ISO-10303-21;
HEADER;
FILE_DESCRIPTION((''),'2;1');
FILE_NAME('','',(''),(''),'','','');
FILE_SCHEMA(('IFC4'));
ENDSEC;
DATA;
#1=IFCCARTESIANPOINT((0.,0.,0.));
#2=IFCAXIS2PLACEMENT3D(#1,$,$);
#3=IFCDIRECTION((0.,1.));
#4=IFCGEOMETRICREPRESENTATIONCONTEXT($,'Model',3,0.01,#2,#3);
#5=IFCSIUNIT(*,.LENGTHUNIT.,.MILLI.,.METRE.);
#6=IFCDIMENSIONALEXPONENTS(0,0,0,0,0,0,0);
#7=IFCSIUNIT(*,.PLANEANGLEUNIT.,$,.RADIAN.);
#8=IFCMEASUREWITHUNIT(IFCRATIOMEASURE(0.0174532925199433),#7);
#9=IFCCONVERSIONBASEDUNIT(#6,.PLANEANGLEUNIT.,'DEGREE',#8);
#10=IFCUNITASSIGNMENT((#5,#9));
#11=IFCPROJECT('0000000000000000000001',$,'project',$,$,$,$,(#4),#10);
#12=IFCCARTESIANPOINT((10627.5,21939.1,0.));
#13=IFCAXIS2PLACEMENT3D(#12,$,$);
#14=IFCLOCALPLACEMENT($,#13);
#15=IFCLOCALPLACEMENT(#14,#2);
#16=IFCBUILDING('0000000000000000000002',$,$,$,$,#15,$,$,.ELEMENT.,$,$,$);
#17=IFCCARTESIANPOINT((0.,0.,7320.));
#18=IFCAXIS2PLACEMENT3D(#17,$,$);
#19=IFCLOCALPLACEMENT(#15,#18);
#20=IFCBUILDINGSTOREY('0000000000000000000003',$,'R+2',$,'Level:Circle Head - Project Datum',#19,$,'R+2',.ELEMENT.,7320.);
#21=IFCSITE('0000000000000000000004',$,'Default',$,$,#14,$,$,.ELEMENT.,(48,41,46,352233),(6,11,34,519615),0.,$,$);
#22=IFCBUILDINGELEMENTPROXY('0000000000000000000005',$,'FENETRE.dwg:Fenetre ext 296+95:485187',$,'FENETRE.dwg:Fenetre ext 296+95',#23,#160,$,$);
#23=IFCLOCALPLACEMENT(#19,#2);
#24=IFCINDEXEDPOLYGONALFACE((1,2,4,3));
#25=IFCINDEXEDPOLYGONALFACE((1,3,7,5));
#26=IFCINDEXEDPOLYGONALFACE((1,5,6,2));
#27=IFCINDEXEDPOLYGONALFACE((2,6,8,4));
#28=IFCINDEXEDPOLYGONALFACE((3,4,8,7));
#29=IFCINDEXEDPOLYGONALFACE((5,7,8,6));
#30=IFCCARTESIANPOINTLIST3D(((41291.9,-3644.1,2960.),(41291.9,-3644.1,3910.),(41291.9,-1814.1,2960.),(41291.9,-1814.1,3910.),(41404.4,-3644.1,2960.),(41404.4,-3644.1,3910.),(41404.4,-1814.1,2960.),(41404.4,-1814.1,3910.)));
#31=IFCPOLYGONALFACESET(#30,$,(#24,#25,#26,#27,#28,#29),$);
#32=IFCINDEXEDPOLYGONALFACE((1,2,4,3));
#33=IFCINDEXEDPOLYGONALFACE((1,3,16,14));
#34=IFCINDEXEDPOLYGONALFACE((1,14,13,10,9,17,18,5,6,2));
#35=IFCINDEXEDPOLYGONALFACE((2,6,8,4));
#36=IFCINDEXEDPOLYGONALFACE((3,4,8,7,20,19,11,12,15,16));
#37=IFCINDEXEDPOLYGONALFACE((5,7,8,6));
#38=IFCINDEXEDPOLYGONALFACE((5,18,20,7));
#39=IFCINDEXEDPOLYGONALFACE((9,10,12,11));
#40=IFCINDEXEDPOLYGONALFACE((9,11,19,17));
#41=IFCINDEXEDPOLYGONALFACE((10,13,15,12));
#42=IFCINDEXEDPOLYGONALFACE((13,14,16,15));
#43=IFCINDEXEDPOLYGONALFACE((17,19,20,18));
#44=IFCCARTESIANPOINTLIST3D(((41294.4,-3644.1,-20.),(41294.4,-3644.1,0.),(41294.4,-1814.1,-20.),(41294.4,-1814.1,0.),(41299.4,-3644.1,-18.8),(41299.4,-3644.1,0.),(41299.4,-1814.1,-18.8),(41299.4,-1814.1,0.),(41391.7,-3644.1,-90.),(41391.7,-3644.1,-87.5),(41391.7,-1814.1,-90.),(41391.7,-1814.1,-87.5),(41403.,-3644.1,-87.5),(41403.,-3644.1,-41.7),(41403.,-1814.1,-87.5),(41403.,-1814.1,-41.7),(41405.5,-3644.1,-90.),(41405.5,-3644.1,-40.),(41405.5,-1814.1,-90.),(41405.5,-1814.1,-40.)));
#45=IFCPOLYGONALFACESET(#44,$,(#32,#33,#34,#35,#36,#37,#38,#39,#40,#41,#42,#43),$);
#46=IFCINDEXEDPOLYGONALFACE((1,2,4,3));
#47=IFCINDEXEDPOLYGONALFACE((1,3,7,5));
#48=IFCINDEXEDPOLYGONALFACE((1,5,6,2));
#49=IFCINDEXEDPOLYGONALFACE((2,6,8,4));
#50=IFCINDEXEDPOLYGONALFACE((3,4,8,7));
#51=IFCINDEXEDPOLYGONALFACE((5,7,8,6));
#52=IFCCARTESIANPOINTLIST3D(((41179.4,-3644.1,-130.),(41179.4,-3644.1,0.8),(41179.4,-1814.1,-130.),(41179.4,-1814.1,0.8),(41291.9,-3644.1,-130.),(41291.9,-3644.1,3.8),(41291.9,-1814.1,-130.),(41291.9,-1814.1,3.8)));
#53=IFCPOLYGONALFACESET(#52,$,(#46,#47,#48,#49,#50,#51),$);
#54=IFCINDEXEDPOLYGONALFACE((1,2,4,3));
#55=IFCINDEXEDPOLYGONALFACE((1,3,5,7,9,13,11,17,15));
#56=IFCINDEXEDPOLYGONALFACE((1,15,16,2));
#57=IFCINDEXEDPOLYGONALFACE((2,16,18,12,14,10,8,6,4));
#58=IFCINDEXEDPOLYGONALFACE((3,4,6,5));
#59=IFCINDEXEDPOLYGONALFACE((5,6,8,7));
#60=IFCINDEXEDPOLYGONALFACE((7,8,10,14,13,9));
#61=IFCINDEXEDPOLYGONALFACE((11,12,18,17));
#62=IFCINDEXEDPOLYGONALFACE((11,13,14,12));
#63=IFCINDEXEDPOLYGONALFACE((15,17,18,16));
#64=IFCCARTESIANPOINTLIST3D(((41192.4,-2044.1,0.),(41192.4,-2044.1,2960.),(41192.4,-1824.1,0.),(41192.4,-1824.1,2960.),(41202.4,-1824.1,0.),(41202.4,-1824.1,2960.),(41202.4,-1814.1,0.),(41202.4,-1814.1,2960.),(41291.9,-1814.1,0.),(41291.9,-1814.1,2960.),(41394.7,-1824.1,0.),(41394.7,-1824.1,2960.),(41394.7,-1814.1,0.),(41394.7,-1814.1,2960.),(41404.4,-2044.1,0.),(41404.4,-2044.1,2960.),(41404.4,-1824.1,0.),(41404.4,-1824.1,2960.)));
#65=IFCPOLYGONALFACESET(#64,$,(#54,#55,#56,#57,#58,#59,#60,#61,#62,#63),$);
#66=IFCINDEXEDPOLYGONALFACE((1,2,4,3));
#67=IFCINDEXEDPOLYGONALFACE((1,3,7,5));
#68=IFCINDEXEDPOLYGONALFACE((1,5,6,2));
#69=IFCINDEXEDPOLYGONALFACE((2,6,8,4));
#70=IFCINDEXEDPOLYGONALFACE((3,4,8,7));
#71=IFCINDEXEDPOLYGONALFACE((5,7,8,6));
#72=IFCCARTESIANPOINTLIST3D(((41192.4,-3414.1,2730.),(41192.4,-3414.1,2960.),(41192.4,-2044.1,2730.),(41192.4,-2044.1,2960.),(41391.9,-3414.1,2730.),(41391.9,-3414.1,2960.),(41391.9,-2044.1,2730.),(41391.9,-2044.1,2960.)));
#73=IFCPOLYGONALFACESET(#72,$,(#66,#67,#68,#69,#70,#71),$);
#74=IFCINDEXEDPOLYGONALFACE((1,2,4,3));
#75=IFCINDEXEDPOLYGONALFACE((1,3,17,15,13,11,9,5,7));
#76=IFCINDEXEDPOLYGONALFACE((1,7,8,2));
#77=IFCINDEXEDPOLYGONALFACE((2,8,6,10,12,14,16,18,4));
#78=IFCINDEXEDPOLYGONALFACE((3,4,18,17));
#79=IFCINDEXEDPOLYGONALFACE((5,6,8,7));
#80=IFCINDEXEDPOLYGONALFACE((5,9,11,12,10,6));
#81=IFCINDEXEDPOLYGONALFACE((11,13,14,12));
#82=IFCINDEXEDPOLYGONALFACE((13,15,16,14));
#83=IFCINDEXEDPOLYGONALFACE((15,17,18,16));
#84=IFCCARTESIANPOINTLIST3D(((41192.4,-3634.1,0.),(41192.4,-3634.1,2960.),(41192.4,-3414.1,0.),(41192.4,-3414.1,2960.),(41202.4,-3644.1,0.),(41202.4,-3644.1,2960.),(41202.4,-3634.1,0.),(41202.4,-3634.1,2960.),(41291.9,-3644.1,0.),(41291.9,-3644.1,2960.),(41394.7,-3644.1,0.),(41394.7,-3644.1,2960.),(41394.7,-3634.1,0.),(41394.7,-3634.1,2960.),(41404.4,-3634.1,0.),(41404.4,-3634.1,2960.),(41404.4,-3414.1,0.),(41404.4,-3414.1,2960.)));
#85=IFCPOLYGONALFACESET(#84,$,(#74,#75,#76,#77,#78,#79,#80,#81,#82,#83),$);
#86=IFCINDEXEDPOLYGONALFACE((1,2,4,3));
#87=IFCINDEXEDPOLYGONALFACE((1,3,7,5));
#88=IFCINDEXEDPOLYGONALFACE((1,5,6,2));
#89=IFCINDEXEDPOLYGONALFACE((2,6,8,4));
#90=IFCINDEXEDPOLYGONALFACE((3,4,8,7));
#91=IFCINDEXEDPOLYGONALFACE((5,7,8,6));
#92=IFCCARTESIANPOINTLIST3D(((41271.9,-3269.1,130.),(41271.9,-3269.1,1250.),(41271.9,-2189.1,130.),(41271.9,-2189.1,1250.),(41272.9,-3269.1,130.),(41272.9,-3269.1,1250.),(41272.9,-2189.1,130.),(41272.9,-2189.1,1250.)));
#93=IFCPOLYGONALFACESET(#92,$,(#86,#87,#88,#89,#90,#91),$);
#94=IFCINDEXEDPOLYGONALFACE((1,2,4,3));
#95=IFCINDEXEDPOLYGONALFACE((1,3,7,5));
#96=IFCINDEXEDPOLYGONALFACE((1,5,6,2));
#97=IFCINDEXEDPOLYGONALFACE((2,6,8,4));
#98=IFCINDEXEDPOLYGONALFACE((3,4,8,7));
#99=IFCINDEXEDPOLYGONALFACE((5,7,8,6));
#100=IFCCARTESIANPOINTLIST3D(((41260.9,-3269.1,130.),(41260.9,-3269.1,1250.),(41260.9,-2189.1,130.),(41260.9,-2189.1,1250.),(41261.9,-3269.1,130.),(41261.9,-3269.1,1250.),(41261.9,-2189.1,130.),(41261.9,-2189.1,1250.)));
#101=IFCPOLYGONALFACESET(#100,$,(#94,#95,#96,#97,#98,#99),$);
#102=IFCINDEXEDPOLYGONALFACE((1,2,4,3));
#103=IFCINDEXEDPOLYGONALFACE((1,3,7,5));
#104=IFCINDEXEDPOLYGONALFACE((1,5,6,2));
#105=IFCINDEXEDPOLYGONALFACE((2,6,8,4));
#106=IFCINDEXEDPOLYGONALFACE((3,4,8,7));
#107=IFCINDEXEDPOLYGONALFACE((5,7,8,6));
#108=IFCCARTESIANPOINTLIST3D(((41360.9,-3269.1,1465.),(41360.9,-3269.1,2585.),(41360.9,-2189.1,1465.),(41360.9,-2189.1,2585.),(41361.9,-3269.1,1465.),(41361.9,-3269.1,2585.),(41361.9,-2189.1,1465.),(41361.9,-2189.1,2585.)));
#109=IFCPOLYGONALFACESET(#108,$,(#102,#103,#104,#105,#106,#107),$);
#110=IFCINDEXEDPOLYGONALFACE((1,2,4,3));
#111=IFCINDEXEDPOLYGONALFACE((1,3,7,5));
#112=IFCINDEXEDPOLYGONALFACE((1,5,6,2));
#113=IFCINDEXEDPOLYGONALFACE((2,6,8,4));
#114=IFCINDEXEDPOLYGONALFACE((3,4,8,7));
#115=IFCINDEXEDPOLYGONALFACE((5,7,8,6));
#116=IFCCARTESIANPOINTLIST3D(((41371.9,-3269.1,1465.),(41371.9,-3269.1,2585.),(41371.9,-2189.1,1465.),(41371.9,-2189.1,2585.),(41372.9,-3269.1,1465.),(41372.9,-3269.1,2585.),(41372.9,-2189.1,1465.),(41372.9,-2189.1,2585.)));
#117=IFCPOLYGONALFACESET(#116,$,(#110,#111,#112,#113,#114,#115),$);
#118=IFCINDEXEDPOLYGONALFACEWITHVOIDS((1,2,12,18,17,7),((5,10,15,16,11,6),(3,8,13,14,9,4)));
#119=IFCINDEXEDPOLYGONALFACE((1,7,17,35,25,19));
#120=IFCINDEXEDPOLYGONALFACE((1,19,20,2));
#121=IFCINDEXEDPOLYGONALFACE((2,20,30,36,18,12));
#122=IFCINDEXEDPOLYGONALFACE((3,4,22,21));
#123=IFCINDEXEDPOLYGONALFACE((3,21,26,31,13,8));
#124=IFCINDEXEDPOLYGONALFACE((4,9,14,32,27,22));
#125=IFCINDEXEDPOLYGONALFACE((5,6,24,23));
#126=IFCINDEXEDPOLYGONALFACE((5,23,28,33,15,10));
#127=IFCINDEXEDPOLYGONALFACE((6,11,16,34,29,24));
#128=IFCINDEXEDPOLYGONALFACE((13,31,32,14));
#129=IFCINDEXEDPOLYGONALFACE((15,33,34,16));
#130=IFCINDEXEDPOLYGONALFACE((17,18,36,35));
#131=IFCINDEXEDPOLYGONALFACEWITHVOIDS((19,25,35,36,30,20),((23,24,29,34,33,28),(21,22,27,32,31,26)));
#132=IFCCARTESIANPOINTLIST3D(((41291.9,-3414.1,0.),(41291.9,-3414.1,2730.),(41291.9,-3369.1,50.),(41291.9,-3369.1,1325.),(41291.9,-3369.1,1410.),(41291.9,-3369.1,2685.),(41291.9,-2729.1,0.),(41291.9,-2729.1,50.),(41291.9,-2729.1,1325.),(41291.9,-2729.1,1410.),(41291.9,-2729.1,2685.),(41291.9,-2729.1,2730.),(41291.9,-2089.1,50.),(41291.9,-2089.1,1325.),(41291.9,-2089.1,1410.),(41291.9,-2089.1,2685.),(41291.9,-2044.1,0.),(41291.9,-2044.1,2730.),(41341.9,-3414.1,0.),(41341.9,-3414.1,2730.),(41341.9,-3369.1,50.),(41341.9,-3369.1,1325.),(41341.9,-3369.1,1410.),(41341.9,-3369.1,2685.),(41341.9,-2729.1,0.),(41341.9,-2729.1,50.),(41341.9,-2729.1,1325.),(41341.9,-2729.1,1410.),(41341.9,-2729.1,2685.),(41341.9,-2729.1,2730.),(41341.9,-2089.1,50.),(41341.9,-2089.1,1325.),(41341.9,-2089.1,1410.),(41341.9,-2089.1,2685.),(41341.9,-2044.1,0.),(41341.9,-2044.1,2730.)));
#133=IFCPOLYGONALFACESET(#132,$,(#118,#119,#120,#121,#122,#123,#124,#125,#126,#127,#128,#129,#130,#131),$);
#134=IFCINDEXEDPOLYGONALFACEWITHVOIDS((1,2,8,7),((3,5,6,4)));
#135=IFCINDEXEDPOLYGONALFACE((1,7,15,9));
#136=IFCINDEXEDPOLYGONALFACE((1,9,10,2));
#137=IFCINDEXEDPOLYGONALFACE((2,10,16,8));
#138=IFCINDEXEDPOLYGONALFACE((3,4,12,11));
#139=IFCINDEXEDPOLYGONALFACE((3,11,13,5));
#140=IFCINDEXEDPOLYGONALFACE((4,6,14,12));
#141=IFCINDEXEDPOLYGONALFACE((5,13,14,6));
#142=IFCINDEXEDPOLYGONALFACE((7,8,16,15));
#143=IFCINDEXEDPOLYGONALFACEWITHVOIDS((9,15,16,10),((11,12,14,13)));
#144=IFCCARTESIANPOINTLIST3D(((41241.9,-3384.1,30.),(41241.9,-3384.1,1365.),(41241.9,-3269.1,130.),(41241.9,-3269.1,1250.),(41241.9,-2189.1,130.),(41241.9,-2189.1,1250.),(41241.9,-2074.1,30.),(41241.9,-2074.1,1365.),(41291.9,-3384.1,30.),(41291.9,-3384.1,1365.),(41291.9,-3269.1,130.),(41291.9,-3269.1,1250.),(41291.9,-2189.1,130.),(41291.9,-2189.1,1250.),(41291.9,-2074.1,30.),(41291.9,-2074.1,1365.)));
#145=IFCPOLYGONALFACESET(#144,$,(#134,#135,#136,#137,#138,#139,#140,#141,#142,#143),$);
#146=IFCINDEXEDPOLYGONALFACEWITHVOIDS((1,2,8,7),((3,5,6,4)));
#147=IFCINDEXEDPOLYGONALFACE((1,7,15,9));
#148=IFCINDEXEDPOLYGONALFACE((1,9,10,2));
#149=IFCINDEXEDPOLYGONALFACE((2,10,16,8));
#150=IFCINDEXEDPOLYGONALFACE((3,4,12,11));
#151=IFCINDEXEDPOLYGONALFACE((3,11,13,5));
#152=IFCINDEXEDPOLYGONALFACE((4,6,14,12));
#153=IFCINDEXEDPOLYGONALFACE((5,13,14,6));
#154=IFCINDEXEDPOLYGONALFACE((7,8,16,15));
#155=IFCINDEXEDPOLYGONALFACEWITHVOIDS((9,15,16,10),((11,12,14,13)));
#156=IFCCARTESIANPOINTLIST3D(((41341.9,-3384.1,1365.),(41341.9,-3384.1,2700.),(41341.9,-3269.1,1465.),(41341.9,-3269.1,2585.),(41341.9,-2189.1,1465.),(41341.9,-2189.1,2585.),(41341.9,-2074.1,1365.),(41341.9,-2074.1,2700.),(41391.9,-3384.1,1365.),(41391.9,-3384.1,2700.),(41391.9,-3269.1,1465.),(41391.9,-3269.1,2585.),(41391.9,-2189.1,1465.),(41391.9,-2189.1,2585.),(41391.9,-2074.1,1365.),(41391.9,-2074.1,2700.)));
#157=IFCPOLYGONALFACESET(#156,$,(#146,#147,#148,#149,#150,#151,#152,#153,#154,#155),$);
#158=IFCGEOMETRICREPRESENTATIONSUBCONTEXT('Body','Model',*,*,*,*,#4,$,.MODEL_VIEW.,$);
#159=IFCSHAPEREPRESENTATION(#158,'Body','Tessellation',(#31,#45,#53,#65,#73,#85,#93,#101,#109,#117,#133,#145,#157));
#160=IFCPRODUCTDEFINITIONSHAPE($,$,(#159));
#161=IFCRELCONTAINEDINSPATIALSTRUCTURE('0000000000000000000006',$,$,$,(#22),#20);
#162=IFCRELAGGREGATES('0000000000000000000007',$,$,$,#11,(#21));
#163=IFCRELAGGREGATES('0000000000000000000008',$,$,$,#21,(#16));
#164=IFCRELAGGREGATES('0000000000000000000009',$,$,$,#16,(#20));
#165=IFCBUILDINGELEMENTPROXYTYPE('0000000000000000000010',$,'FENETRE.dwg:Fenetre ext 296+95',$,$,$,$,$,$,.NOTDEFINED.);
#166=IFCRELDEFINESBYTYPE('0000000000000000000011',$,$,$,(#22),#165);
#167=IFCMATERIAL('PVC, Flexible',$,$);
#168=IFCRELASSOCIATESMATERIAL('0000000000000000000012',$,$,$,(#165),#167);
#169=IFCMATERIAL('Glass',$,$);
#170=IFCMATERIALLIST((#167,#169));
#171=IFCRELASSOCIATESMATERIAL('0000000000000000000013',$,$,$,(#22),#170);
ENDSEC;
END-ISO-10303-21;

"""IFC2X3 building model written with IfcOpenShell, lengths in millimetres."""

from ifc_helpers import new_model, entity, si_unit, converted_unit, direction, frame, frame_2d, origin, origin_2d_with_axis, place, context, subcontext, project, spatial, polyline, rectangle, outline, extrude, source, transform, mapped, material, material_list, type_object, type_shapes, element, save


model = new_model("IFC2X3")

# Units and contexts
model_context = context("Model", 3, precision=0.01, world=origin(), true_north=direction((0.0, 1.0)))
body_context = subcontext(model_context, "Body", "Model", "MODEL_VIEW")
ifc_project = project(units=[si_unit("LENGTHUNIT", "METRE", prefix="MILLI"), converted_unit("PLANEANGLEUNIT", "DEGREE", entity("IfcRatioMeasure", 0.0174532925199433), si_unit("PLANEANGLEUNIT", "RADIAN"), dimensions=[0, 0, 0, 0, 0, 0, 0])], contexts=[model_context])

# Site, building, storey
site_placement = place(None, frame((10627.5, 21939.1, 0.0)))
site = spatial("IfcSite", under=ifc_project, at=site_placement, Name="Default", CompositionType="ELEMENT", RefLatitude=(48, 41, 46, 352233), RefLongitude=(6, 11, 34, 519615), RefElevation=0.0)
building_placement = place(site_placement, origin())
building = spatial("IfcBuilding", under=site, at=building_placement, CompositionType="ELEMENT")
storey_placement = place(building_placement, frame((0.0, 0.0, 7320.0)))
storey = spatial("IfcBuildingStorey", under=building, at=storey_placement, Name="R+2", ObjectType="Level:Circle Head - Project Datum", LongName="R+2", CompositionType="ELEMENT", Elevation=7320.0)

# Building element proxy
ifc_material_1 = material(Name="PVC, Flexible")
ifc_material_2 = material(Name="Glass")
building_element_proxy_type_1 = type_object("IfcBuildingElementProxyType", Name="FENETRE.dwg:Fenetre ext 296+95", PredefinedType="NOTDEFINED", material=ifc_material_1)
shared_shape_1 = source(origin(), body_context, "Body", "SweptSolid", [
    extrude(rectangle(XDim=112.5, YDim=1830.0, at=origin_2d_with_axis()), frame((-10.4, -56.3, 2960.0), z_axis=(0.0, 0.0, 1.0), x_axis=(0.0, 1.0, 0.0)), (0.0, 0.0, 1.0), 950.0),
    extrude(outline(polyline([(27.5, -64.4), (47.5, -64.4), (47.5, -59.4), (28.8, -59.4), (7.5, 46.7), (-42.5, 46.7), (-42.5, 32.9), (-40.0, 32.9), (-40.0, 44.2), (5.8, 44.2), (27.5, -64.4)])), frame((-925.4, -66.9, -47.5), z_axis=(1.0, 0.0, 0.0), x_axis=(0.0, 0.0, 1.0)), (0.0, 0.0, 1.0), 1830.0),
    extrude(outline(polyline([(-54.5, -66.1), (58.0, -66.1), (54.5, 67.6), (-58.0, 64.6), (-54.5, -66.1)])), frame((-925.4, 56.3, -63.8), z_axis=(1.0, 0.0, 0.0), x_axis=(0.0, -0.999645, 0.02665)), (0.0, 0.0, 1.0), 1830.0),
    extrude(outline(polyline([(-97.0, -55.6), (5.9, -55.6), (95.4, -55.6), (95.4, -45.6), (105.4, -45.6), (105.4, 174.4), (-106.6, 174.4), (-106.6, -45.6), (-97.0, -45.6), (-97.0, -55.6)])), frame((849.0, -5.9, 0.0), z_axis=(0.0, 0.0, 1.0), x_axis=(0.0, 1.0, 0.0)), (0.0, 0.0, 1.0), 2960.0),
    extrude(rectangle(XDim=1370.0, YDim=199.5, at=origin_2d_with_axis()), frame((-10.4, -0.3, 2730.0), z_axis=(0.0, 0.0, 1.0), x_axis=(-1.0, 0.0, 0.0)), (0.0, 0.0, 1.0), 230.0),
    extrude(outline(polyline([(-55.6, 97.0), (-55.6, -5.9), (-55.6, -95.4), (-45.6, -95.4), (-45.6, -105.4), (174.4, -105.4), (174.4, 106.6), (-45.6, 106.6), (-45.6, 97.0), (-55.6, 97.0)])), frame((-869.9, -5.9, 0.0), z_axis=(0.0, 0.0, -1.0), x_axis=(1.0, 0.0, 0.0)), (0.0, 0.0, -1.0), 2960.0),
    extrude(rectangle(XDim=1080.0, YDim=1.0, at=origin_2d_with_axis()), frame((-10.4, 19.5, 130.0), z_axis=(0.0, 0.0, 1.0), x_axis=(-1.0, 0.0, 0.0)), (0.0, 0.0, 1.0), 1120.0),
    extrude(rectangle(XDim=1080.0, YDim=1.0, at=origin_2d_with_axis()), frame((-10.4, 30.5, 130.0), z_axis=(0.0, 0.0, 1.0), x_axis=(-1.0, 0.0, 0.0)), (0.0, 0.0, 1.0), 1120.0),
    extrude(rectangle(XDim=1080.0, YDim=1.0, at=frame_2d((0.0, 0.0), x_axis=(1.0, 0.0))), frame((-10.4, -69.5, 1465.0), z_axis=(0.0, 0.0, 1.0), x_axis=(-1.0, 0.0, 0.0)), (0.0, 0.0, 1.0), 1120.0),
    extrude(rectangle(XDim=1080.0, YDim=1.0, at=frame_2d((0.0, 0.0), x_axis=(1.0, 0.0))), frame((-10.4, -80.5, 1465.0), z_axis=(0.0, 0.0, 1.0), x_axis=(-1.0, 0.0, 0.0)), (0.0, 0.0, 1.0), 1120.0),
    extrude(outline(polyline([(-685.0, -1365.0), (0.0, -1365.0), (685.0, -1365.0), (685.0, 1365.0), (0.0, 1365.0), (-685.0, 1365.0), (-685.0, -1365.0)]), holes=[polyline([(-640.0, -1320.0), (-640.0, -45.0), (0.0, -45.0), (640.0, -45.0), (640.0, -1320.0), (0.0, -1320.0), (-640.0, -1320.0)]), polyline([(-640.0, 40.0), (-640.0, 1315.0), (0.0, 1315.0), (640.0, 1315.0), (640.0, 40.0), (0.0, 40.0), (-640.0, 40.0)])]), frame((-10.4, -50.0, 1365.0), z_axis=(0.0, 1.0, 0.0), x_axis=(1.0, 0.0, 0.0)), (0.0, 0.0, 1.0), 50.0),
    extrude(outline(polyline([(-655.0, -667.5), (655.0, -667.5), (655.0, 667.5), (-655.0, 667.5), (-655.0, -667.5)]), holes=[polyline([(-540.0, 552.5), (540.0, 552.5), (540.0, -567.5), (-540.0, -567.5), (-540.0, 552.5)])]), frame((-10.4, 0.0, 697.5), z_axis=(0.0, 1.0, 0.0), x_axis=(-1.0, 0.0, 0.0)), (0.0, 0.0, 1.0), 50.0),
    extrude(outline(polyline([(-655.0, -667.5), (655.0, -667.5), (655.0, 667.5), (-655.0, 667.5), (-655.0, -667.5)]), holes=[polyline([(-540.0, 552.5), (540.0, 552.5), (540.0, -567.5), (-540.0, -567.5), (-540.0, 552.5)])]), frame((-10.4, -100.0, 2032.5), z_axis=(0.0, 1.0, 0.0), x_axis=(-1.0, 0.0, 0.0)), (0.0, 0.0, 1.0), 50.0),
])
type_shapes(building_element_proxy_type_1, [shared_shape_1])
ifc_material_list_1 = material_list([ifc_material_1, ifc_material_2])
proxy_1_placement = place(storey_placement, frame((41291.9, -2718.7, 0.0), z_axis=(0.0, 0.0, 1.0), x_axis=(0.0, 1.0, 0.0)))
element("IfcBuildingElementProxy", 1, at=proxy_1_placement, inside=storey, type_object=building_element_proxy_type_1, material=ifc_material_list_1, Name="FENETRE.dwg:Fenetre ext 296+95:485187", ObjectType="FENETRE.dwg:Fenetre ext 296+95", context=body_context, shape_type="MappedRepresentation", body=[
    mapped(shared_shape_1, transform((0.0, 0.0, 0.0), scale=1.0)),
])

save(model, "model.ifc")
